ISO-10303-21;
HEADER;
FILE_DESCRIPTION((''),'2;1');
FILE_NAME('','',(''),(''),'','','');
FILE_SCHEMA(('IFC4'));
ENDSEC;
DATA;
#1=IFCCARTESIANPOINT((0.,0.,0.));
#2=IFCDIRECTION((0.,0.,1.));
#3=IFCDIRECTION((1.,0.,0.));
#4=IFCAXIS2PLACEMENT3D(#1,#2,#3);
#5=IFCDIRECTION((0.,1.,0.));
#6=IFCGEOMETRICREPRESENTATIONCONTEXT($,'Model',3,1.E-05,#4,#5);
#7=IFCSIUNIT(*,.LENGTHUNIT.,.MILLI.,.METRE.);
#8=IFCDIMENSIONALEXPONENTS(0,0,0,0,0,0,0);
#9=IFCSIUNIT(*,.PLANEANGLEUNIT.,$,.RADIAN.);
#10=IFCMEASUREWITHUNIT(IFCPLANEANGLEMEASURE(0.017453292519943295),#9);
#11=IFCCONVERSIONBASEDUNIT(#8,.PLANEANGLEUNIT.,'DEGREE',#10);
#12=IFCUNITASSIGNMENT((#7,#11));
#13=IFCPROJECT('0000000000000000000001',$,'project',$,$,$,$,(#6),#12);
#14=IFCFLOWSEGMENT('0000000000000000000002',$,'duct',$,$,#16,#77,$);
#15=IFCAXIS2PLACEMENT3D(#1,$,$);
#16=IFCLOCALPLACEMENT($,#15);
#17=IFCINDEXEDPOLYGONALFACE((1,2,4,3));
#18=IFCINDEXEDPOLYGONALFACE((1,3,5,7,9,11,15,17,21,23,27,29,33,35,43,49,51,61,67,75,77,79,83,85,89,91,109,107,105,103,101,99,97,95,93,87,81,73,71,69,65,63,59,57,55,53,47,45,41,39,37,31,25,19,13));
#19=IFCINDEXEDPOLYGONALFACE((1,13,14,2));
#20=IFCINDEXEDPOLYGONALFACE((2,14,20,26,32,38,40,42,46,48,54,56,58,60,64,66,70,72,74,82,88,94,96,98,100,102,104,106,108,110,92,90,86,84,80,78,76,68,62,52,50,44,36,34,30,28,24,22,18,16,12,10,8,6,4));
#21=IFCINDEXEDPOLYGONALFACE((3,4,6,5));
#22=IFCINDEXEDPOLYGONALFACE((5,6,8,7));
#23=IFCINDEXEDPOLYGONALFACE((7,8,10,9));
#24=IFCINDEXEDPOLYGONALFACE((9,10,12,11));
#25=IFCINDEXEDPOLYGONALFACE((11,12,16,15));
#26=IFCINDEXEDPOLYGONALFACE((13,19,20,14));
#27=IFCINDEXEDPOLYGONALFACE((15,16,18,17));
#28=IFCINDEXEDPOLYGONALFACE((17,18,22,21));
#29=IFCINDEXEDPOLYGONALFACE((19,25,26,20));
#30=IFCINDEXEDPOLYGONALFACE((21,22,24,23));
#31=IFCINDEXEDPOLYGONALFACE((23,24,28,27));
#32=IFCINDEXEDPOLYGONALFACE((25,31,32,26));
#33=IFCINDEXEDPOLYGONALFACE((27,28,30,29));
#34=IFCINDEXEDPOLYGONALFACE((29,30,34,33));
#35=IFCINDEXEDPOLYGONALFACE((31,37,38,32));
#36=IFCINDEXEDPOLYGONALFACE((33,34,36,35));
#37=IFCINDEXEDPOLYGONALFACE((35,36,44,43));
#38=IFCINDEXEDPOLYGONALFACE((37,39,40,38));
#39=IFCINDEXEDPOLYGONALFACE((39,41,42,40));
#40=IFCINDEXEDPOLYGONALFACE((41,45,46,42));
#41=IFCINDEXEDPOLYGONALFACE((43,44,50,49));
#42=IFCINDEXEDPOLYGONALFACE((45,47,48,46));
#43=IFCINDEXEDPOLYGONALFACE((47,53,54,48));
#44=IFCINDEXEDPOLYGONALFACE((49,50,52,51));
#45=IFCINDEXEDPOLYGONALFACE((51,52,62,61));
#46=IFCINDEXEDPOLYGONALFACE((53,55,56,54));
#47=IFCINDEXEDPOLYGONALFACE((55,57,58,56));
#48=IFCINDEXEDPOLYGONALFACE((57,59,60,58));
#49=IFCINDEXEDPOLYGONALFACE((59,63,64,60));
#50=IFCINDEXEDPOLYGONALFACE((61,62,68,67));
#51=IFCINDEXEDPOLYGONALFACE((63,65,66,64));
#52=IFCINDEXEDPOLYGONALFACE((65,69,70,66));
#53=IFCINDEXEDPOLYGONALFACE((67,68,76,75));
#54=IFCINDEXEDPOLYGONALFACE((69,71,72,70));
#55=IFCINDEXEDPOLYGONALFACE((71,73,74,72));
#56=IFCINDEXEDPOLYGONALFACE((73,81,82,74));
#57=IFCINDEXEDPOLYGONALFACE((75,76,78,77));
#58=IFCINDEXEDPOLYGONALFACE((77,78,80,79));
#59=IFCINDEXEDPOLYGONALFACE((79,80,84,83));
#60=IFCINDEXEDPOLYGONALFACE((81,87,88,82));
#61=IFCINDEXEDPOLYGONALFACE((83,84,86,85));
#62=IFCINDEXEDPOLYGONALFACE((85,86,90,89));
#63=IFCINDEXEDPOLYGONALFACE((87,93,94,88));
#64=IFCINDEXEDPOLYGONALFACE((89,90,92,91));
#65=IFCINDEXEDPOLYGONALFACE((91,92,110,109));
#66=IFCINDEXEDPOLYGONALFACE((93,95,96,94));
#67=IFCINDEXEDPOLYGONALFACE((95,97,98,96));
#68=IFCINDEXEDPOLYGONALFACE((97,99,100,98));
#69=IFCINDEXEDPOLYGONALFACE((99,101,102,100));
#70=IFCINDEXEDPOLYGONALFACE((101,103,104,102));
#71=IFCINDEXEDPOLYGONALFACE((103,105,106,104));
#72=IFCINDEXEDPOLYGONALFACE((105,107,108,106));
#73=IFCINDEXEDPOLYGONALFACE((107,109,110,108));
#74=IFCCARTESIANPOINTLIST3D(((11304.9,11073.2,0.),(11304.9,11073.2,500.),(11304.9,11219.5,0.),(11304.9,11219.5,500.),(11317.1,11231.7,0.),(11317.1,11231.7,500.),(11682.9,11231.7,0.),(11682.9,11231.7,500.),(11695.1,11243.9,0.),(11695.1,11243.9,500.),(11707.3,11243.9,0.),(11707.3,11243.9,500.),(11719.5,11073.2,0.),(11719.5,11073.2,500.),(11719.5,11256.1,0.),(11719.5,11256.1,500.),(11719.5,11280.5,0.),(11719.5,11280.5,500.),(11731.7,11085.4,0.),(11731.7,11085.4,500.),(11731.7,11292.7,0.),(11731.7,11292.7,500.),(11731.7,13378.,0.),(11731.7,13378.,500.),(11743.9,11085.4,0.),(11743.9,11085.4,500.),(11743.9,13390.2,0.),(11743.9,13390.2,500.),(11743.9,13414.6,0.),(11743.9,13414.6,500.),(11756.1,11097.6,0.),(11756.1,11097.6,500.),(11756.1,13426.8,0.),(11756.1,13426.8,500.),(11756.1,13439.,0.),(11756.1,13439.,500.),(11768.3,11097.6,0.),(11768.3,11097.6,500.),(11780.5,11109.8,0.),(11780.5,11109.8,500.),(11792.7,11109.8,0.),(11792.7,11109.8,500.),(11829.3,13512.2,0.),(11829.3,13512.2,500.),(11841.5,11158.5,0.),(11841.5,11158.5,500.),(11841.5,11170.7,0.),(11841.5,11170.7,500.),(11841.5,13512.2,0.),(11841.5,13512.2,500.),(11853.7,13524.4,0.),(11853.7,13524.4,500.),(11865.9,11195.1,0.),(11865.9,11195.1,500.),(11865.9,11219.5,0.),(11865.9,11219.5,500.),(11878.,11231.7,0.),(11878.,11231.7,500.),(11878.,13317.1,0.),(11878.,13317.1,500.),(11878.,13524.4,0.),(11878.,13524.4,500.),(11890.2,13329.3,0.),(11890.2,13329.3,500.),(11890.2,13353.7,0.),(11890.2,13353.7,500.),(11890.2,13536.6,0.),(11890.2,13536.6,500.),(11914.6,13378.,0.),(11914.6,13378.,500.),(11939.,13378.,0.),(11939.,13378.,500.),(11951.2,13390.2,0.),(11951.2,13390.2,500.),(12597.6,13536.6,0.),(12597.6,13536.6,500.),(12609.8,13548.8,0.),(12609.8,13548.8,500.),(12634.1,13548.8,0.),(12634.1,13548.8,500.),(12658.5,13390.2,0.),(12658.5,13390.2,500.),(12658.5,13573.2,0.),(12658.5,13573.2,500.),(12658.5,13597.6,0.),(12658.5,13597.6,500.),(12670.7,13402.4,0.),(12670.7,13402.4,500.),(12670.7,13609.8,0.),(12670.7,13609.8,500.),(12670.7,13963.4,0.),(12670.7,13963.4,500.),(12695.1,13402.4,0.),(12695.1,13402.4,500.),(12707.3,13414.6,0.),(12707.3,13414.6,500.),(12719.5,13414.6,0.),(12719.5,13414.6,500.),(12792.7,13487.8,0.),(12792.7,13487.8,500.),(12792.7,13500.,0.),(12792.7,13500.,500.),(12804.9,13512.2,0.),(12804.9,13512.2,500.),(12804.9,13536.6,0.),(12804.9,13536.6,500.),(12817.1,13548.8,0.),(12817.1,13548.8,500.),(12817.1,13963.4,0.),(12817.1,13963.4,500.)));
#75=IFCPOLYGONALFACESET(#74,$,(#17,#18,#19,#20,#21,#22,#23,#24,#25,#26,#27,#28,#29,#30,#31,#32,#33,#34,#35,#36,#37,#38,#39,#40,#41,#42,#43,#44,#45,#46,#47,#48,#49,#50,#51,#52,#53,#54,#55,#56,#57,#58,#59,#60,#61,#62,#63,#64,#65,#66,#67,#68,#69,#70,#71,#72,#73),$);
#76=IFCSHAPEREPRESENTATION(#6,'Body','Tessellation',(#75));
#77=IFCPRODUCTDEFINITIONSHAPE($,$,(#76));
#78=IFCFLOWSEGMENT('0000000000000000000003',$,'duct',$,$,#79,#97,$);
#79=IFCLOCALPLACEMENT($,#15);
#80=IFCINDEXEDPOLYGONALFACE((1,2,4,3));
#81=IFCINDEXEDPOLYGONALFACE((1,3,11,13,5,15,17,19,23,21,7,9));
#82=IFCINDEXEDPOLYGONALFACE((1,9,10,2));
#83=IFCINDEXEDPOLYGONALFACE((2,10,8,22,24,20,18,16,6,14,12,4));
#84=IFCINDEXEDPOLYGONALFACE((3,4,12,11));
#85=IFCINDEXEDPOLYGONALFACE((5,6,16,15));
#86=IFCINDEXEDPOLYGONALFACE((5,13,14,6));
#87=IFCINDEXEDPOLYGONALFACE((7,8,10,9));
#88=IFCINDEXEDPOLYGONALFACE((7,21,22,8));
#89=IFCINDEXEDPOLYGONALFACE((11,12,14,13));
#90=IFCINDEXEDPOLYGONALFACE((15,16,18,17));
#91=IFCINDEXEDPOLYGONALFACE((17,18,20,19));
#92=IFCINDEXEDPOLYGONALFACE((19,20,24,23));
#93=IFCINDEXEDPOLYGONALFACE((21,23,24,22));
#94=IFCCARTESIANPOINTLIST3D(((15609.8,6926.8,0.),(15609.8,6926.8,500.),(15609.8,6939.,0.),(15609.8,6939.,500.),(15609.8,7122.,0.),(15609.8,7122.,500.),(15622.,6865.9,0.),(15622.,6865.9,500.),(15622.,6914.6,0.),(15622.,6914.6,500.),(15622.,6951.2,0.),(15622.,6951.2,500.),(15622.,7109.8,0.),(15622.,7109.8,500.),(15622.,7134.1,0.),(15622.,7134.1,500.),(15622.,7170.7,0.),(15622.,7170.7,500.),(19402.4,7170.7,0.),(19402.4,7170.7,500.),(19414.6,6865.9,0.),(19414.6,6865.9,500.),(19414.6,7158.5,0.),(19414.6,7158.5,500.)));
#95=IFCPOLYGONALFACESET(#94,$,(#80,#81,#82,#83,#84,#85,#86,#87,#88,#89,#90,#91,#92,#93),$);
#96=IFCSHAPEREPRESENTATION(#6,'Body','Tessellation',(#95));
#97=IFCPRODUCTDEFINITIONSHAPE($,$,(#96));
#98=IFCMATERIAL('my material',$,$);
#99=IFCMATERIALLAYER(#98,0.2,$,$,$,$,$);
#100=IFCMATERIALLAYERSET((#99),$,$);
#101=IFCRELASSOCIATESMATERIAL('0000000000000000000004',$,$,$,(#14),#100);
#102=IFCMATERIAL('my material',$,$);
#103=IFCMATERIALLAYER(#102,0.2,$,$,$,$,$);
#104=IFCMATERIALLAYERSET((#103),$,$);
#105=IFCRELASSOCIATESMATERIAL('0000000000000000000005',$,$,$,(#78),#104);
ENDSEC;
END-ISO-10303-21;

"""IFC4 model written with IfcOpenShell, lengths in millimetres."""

from ifc_helpers import new_model, entity, si_unit, converted_unit, direction, origin_with_axes, place, context, project, polyline, outline, extrude, material, layer, layer_set, layer_usage, element, save


model = new_model("IFC4")

# Units and contexts
model_context = context("Model", 3, precision=1e-05, world=origin_with_axes(), true_north=direction((0.0, 1.0, 0.0)))
ifc_project = project(units=[si_unit("LENGTHUNIT", "METRE", prefix="MILLI"), converted_unit("PLANEANGLEUNIT", "DEGREE", entity("IfcPlaneAngleMeasure", 0.017453292519943295), si_unit("PLANEANGLEUNIT", "RADIAN"), dimensions=[0, 0, 0, 0, 0, 0, 0])], contexts=[model_context])

# Flow segments
ifc_material_1 = material(Name="my material")
ifc_layer_1 = layer(ifc_material_1, 0.2)
ifc_layer_set_1 = layer_set([ifc_layer_1])
ifc_layer_usage_1 = layer_usage(ifc_layer_set_1, "AXIS2", "POSITIVE", -0.1)
flow_segment_1_placement = place(None, origin_with_axes())
element("IfcFlowSegment", 1, at=flow_segment_1_placement, material=ifc_layer_usage_1, Name="duct", context=model_context, shape_type="SweptSolid", body=[
    extrude(outline(polyline([(11304.9, 11073.2), (11719.5, 11073.2), (11731.7, 11085.4), (11743.9, 11085.4), (11756.1, 11097.6), (11768.3, 11097.6), (11780.5, 11109.8), (11792.7, 11109.8), (11841.5, 11158.5), (11841.5, 11170.7), (11865.9, 11195.1), (11865.9, 11219.5), (11878.0, 11231.7), (11878.0, 13317.1), (11890.2, 13329.3), (11890.2, 13353.7), (11914.6, 13378.0), (11939.0, 13378.0), (11951.2, 13390.2), (12658.5, 13390.2), (12670.7, 13402.4), (12695.1, 13402.4), (12707.3, 13414.6), (12719.5, 13414.6), (12792.7, 13487.8), (12792.7, 13500.0), (12804.9, 13512.2), (12804.9, 13536.6), (12817.1, 13548.8), (12817.1, 13963.4), (12670.7, 13963.4), (12670.7, 13609.8), (12658.5, 13597.6), (12658.5, 13573.2), (12634.1, 13548.8), (12609.8, 13548.8), (12597.6, 13536.6), (11890.2, 13536.6), (11878.0, 13524.4), (11853.7, 13524.4), (11841.5, 13512.2), (11829.3, 13512.2), (11756.1, 13439.0), (11756.1, 13426.8), (11743.9, 13414.6), (11743.9, 13390.2), (11731.7, 13378.0), (11731.7, 11292.7), (11719.5, 11280.5), (11719.5, 11256.1), (11707.3, 11243.9), (11695.1, 11243.9), (11682.9, 11231.7), (11317.1, 11231.7), (11304.9, 11219.5), (11304.9, 11073.2)])), origin_with_axes(), (0.0, 0.0, 1.0), 500.0),
])
ifc_material_2 = material(Name="my material")
ifc_layer_2 = layer(ifc_material_2, 0.2)
ifc_layer_set_2 = layer_set([ifc_layer_2])
ifc_layer_usage_2 = layer_usage(ifc_layer_set_2, "AXIS2", "POSITIVE", -0.1)
flow_segment_2_placement = place(None, origin_with_axes())
element("IfcFlowSegment", 2, at=flow_segment_2_placement, material=ifc_layer_usage_2, Name="duct", context=model_context, shape_type="SweptSolid", body=[
    extrude(outline(polyline([(15609.8, 6926.8), (15622.0, 6914.6), (15622.0, 6865.9), (19414.6, 6865.9), (19414.6, 7158.5), (19402.4, 7170.7), (15622.0, 7170.7), (15622.0, 7134.1), (15609.8, 7122.0), (15622.0, 7109.8), (15622.0, 6951.2), (15609.8, 6939.0), (15609.8, 6926.8)])), origin_with_axes(), (0.0, 0.0, 1.0), 500.0),
])

save(model, "model.ifc")
